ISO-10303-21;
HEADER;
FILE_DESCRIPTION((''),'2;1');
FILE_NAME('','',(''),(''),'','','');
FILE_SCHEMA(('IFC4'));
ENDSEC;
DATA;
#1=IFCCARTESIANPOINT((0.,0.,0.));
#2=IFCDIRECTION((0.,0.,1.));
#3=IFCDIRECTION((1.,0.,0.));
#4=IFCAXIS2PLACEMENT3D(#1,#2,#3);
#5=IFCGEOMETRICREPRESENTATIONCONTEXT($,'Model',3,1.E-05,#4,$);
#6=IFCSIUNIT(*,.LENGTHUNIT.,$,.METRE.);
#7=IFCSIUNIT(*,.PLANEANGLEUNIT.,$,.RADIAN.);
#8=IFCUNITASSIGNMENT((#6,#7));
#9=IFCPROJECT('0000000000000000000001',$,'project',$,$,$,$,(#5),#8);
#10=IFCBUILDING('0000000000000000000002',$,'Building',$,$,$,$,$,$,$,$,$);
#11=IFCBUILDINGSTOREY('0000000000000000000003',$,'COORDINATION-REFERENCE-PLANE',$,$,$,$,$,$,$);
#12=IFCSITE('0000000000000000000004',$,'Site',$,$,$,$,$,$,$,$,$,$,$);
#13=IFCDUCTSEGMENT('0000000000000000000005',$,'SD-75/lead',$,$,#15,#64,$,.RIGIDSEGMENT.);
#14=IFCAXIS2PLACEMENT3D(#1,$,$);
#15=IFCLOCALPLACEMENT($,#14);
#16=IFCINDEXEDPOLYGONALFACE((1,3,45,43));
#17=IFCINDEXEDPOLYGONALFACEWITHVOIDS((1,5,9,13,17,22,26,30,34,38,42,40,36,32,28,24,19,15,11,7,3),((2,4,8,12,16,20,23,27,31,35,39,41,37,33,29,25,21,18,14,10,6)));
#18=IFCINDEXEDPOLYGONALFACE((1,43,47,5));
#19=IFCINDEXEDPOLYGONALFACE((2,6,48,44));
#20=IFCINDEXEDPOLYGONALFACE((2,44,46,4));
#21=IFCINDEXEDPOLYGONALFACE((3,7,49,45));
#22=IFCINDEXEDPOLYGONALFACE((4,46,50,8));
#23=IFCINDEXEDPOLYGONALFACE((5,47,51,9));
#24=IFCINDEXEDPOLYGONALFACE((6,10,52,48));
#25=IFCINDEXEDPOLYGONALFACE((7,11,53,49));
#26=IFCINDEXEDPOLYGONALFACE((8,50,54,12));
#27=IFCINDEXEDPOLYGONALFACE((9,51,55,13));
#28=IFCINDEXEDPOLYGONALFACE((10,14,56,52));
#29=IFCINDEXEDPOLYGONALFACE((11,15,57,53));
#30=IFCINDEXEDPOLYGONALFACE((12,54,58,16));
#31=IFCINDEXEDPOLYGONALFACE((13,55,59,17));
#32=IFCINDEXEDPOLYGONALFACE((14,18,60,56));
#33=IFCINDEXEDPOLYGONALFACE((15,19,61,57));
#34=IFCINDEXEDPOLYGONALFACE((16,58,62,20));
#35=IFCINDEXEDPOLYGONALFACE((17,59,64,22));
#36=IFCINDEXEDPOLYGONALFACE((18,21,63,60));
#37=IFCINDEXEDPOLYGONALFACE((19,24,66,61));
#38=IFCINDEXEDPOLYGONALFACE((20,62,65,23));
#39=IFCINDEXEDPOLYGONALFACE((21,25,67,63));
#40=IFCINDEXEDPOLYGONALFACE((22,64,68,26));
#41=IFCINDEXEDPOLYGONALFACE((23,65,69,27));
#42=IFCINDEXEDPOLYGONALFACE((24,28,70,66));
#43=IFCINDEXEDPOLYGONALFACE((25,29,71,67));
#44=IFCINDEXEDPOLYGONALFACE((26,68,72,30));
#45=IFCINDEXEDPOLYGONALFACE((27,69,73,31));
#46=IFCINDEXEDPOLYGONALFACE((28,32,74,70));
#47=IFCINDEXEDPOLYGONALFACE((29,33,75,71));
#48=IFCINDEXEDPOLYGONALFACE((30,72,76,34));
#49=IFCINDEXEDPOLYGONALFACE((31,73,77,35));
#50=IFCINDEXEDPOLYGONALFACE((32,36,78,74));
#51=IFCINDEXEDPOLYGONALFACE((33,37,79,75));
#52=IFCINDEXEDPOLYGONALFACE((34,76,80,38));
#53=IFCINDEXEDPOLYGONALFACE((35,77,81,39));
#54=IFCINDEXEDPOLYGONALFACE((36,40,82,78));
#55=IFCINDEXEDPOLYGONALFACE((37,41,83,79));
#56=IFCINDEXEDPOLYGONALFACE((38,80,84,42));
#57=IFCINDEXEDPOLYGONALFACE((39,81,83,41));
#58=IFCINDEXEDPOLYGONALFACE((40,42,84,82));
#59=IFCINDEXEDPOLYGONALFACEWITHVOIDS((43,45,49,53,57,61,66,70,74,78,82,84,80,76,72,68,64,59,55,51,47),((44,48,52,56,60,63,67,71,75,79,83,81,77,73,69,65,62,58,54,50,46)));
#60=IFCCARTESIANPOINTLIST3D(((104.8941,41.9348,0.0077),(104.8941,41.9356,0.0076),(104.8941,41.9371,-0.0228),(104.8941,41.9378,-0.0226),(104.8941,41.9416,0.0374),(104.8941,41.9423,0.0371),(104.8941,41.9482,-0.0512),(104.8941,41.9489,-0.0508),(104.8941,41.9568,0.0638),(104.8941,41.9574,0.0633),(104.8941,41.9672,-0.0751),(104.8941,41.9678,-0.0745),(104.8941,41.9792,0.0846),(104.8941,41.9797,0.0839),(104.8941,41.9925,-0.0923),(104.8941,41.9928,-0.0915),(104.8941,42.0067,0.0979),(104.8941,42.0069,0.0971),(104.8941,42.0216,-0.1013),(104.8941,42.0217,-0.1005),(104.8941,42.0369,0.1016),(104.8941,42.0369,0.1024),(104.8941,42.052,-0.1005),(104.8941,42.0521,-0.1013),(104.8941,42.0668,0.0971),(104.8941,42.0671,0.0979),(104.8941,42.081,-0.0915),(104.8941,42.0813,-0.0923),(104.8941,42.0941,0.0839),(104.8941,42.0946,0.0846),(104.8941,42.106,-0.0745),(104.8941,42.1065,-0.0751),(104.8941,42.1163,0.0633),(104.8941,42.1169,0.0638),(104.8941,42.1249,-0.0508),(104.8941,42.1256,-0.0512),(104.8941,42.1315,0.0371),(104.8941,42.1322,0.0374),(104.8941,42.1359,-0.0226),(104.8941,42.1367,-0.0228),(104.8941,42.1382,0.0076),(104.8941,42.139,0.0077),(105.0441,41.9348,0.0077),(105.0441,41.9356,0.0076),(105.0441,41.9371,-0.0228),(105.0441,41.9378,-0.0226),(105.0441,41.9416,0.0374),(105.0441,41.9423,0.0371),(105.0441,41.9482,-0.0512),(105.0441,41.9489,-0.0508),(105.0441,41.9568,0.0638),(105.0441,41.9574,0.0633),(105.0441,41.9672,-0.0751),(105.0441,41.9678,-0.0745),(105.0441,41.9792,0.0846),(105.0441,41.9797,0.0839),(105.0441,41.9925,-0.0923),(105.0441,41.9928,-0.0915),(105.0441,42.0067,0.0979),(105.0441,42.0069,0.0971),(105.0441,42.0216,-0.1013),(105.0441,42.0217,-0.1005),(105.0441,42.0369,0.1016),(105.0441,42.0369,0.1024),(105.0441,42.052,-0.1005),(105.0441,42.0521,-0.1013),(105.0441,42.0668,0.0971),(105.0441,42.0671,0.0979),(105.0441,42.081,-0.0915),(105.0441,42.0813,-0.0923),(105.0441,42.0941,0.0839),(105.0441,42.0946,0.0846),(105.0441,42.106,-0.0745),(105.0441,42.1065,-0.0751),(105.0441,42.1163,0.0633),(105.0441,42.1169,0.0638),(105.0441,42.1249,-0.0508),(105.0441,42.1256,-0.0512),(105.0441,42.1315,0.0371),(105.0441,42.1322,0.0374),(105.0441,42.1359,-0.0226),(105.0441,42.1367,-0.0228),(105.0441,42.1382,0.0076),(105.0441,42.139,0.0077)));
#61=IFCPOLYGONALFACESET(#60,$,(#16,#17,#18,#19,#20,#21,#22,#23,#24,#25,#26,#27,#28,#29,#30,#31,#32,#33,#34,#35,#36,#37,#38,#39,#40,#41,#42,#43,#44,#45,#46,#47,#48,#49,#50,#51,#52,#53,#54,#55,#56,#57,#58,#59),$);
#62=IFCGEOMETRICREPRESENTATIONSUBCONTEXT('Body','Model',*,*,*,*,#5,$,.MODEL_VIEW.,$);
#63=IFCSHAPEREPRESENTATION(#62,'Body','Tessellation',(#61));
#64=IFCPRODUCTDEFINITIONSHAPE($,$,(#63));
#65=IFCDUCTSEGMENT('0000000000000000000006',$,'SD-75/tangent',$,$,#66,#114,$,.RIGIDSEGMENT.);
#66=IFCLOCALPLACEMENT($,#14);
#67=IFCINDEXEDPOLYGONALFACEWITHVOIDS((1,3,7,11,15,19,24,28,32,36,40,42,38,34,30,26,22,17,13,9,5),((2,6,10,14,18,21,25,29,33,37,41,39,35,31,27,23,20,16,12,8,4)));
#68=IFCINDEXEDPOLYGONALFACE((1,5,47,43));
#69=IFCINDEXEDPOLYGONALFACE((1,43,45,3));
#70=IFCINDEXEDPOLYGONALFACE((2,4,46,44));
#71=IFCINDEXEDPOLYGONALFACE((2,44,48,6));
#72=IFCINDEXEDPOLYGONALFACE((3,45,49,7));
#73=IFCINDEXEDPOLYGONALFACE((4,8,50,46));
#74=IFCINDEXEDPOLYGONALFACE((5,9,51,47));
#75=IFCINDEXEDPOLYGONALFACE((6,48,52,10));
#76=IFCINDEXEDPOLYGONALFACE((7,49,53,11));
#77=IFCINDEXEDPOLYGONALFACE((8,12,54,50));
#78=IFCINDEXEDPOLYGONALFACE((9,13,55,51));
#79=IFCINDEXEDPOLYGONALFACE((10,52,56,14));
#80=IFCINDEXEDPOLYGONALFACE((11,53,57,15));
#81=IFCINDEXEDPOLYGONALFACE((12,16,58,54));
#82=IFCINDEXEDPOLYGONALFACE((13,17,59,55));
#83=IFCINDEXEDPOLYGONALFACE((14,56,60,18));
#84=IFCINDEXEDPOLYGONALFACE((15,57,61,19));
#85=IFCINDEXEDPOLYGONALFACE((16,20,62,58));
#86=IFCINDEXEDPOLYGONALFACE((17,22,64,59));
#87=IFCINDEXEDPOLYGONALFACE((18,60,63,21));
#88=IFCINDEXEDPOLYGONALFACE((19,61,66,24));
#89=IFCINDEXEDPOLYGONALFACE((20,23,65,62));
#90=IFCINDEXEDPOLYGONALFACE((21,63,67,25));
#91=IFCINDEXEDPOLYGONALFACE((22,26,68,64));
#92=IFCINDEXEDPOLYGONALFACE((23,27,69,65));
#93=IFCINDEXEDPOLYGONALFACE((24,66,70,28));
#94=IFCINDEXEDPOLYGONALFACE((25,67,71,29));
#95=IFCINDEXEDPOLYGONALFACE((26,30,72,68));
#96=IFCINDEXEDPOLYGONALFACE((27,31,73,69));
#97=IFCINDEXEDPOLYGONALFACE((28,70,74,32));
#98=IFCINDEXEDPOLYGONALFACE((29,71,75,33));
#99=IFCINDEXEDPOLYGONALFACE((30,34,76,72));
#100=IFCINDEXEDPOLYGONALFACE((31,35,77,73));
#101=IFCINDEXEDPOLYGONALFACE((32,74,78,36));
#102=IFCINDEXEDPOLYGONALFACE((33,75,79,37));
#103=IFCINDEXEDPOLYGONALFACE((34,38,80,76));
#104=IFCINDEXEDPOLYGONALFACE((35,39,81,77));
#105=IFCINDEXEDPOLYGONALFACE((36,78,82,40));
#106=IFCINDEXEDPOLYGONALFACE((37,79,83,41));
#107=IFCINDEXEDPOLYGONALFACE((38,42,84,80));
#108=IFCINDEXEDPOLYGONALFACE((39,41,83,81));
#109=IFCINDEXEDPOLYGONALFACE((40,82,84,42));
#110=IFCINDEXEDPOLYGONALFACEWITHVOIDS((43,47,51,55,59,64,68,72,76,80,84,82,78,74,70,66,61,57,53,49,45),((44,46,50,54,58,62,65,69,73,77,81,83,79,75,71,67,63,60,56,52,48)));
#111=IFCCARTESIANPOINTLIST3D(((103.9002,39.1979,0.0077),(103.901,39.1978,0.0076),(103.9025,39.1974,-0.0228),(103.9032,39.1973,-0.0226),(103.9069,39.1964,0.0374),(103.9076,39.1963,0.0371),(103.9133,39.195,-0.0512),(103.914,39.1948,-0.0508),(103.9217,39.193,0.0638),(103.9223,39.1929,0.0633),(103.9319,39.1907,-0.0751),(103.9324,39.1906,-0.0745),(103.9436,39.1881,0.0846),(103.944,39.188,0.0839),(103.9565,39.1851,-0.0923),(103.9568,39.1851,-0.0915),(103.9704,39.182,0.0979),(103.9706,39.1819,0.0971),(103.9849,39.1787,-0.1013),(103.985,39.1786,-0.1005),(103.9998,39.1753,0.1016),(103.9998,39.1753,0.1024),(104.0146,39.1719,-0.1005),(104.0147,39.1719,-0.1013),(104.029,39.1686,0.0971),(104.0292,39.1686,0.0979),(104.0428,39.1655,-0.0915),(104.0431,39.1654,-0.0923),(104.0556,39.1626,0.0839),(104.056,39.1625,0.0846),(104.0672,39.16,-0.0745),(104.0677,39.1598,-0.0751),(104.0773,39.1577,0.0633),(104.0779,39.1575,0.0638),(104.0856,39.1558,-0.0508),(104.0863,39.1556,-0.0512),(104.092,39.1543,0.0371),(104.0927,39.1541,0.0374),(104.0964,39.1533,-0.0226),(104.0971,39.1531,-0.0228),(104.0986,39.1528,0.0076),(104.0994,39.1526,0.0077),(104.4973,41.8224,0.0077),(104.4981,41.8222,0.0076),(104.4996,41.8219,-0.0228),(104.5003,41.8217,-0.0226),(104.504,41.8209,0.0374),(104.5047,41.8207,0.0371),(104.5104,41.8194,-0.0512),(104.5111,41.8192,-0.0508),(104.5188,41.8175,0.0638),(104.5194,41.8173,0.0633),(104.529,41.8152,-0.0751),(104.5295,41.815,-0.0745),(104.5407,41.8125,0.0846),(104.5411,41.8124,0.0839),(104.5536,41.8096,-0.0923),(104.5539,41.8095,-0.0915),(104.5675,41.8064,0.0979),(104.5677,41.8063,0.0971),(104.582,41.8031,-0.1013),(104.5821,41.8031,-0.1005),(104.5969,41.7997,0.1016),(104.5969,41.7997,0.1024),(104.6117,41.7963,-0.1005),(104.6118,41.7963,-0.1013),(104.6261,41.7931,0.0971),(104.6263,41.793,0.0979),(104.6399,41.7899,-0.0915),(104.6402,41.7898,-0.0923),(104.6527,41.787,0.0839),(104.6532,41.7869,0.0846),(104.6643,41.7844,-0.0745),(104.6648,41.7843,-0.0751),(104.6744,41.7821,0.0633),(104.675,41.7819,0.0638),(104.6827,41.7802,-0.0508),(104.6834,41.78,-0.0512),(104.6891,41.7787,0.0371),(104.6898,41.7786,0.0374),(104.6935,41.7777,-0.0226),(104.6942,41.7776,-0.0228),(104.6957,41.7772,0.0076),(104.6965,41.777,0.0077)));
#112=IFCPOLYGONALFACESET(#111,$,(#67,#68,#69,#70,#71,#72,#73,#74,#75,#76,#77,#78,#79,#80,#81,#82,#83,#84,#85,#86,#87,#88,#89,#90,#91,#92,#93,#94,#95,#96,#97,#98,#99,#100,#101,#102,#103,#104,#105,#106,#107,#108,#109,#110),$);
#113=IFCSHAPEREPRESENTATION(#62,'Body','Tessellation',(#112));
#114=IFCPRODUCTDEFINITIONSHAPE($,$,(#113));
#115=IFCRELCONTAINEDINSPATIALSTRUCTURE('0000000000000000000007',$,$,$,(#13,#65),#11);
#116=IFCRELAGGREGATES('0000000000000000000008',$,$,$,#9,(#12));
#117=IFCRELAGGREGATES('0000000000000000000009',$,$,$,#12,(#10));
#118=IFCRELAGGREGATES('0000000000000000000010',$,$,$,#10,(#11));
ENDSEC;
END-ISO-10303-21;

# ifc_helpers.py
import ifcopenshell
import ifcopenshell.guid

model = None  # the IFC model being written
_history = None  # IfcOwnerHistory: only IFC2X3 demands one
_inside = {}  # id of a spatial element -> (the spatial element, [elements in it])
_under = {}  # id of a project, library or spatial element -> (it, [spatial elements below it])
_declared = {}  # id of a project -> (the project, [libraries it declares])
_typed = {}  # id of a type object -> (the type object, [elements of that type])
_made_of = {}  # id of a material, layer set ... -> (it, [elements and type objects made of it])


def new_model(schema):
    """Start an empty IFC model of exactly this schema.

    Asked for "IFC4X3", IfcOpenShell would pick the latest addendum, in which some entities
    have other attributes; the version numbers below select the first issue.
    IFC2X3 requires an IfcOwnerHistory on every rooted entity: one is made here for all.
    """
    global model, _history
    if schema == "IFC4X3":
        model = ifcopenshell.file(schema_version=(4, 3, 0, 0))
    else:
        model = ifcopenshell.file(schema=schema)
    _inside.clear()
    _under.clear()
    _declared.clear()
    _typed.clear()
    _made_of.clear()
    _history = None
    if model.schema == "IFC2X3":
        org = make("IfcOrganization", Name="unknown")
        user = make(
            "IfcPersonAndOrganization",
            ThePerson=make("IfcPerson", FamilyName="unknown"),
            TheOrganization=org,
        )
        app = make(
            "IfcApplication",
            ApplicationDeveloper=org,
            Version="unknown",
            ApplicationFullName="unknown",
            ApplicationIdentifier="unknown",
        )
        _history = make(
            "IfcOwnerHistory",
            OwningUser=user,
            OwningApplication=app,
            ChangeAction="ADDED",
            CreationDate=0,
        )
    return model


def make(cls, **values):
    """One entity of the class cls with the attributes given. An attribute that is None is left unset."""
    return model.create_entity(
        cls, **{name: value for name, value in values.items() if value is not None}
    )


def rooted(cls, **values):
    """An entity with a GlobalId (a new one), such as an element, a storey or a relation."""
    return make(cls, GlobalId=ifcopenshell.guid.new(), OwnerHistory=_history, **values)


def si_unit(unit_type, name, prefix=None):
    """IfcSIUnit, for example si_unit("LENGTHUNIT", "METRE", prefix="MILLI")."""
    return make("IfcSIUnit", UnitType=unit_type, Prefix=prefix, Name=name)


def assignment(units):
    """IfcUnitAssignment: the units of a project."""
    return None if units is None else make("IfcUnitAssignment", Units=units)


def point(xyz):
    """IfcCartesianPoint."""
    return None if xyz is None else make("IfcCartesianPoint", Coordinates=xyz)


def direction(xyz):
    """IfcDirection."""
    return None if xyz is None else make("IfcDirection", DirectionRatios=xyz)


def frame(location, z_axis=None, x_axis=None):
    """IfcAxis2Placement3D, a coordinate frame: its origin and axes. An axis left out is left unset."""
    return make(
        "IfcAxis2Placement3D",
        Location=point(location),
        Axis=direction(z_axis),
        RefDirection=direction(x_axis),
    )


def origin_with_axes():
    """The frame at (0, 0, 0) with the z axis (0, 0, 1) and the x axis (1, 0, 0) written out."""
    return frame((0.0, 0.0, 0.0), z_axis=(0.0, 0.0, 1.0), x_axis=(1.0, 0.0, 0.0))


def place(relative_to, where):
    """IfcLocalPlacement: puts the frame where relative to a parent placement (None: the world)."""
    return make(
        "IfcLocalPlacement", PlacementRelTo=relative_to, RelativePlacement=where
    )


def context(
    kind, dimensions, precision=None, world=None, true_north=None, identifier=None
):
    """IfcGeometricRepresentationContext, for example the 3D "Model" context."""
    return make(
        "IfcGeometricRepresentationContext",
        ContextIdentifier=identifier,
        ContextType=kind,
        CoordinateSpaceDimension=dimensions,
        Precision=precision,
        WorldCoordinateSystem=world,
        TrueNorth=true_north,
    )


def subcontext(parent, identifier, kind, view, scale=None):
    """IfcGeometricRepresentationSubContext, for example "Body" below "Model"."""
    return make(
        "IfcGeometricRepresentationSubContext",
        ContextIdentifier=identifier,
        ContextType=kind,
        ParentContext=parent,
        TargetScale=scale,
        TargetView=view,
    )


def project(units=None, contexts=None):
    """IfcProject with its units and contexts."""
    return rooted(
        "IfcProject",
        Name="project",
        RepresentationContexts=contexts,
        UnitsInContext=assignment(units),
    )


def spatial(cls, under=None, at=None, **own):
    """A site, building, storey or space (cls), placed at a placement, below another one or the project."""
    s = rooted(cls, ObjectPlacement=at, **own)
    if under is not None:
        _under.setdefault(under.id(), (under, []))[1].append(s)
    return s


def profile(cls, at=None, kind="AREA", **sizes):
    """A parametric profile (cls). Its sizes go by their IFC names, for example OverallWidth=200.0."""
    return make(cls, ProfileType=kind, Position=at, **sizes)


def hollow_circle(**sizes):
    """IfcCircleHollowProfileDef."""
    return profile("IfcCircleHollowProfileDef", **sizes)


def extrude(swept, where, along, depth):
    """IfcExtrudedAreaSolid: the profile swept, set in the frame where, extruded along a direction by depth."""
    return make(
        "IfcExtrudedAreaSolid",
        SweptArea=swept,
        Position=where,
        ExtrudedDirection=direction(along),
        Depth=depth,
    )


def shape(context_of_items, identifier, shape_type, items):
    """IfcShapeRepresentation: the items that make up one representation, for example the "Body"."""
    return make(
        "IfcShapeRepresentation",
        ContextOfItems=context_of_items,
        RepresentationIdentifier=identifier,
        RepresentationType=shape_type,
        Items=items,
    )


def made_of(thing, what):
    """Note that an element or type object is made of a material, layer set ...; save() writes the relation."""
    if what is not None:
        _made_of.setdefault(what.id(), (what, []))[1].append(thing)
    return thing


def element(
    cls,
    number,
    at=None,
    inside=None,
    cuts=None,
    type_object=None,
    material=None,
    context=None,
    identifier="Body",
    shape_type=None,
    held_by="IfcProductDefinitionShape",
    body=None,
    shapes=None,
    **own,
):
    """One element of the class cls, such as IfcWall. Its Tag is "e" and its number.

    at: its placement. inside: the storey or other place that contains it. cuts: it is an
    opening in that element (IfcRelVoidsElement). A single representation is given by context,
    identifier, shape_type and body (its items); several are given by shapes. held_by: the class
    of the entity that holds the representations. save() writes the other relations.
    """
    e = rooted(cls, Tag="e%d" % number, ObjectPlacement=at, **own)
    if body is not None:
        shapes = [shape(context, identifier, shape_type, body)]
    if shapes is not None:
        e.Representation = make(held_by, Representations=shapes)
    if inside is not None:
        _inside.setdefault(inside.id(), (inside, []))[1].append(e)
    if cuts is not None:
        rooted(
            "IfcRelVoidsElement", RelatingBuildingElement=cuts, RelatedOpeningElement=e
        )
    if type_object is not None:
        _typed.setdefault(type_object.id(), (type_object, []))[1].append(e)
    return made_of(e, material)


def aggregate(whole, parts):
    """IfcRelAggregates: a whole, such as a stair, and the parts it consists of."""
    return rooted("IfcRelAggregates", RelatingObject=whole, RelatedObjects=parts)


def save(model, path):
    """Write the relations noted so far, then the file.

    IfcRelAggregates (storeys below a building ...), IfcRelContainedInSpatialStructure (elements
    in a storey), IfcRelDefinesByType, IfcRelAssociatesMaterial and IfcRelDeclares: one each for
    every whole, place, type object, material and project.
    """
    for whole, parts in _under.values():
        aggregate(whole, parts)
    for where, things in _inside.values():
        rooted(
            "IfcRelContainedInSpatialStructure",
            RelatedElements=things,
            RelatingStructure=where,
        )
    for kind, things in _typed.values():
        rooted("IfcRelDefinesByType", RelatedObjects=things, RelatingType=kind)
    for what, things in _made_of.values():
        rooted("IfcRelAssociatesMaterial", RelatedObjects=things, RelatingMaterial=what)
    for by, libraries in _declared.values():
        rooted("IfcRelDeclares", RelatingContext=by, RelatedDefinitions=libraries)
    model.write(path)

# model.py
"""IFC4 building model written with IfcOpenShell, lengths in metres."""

from ifc_helpers import new_model, si_unit, frame, origin_with_axes, place, context, subcontext, project, spatial, hollow_circle, extrude, element, save


model = new_model("IFC4")

# Units and contexts
model_context = context("Model", 3, precision=1e-05, world=origin_with_axes())
body_context_1 = subcontext(model_context, "Body", "Model", "MODEL_VIEW")
ifc_project = project(units=[si_unit("LENGTHUNIT", "METRE"), si_unit("PLANEANGLEUNIT", "RADIAN")], contexts=[model_context])

# Site, building, storey
site = spatial("IfcSite", under=ifc_project, Name="Site")
building = spatial("IfcBuilding", under=site, Name="Building")
storey = spatial("IfcBuildingStorey", under=building, Name="COORDINATION-REFERENCE-PLANE")

# Duct segment
duct_segment_1_placement = place(None, frame((105.0441, 42.0369, 0.0), z_axis=(-1.0, 0.0, 0.0), x_axis=(0.0, 0.0, 1.0)))
element("IfcDuctSegment", 1, at=duct_segment_1_placement, inside=storey, Name="SD-75/lead", PredefinedType="RIGIDSEGMENT", context=body_context_1, shape_type="SweptSolid", body=[
    extrude(hollow_circle(Radius=0.1024, WallThickness=0.0008), origin_with_axes(), (0.0, 0.0, 1.0), 0.15),
])

# Duct segment
duct_segment_2_placement = place(None, frame((104.5969, 41.7997, 0.0), z_axis=(-0.221849, -0.975081, 0.0), x_axis=(0.0, 0.0, 1.0)))
element("IfcDuctSegment", 2, at=duct_segment_2_placement, inside=storey, Name="SD-75/tangent", PredefinedType="RIGIDSEGMENT", context=body_context_1, shape_type="SweptSolid", body=[
    extrude(hollow_circle(Radius=0.1024, WallThickness=0.0008), origin_with_axes(), (0.0, 0.0, 1.0), 2.6915),
])

save(model, "model.ifc")
